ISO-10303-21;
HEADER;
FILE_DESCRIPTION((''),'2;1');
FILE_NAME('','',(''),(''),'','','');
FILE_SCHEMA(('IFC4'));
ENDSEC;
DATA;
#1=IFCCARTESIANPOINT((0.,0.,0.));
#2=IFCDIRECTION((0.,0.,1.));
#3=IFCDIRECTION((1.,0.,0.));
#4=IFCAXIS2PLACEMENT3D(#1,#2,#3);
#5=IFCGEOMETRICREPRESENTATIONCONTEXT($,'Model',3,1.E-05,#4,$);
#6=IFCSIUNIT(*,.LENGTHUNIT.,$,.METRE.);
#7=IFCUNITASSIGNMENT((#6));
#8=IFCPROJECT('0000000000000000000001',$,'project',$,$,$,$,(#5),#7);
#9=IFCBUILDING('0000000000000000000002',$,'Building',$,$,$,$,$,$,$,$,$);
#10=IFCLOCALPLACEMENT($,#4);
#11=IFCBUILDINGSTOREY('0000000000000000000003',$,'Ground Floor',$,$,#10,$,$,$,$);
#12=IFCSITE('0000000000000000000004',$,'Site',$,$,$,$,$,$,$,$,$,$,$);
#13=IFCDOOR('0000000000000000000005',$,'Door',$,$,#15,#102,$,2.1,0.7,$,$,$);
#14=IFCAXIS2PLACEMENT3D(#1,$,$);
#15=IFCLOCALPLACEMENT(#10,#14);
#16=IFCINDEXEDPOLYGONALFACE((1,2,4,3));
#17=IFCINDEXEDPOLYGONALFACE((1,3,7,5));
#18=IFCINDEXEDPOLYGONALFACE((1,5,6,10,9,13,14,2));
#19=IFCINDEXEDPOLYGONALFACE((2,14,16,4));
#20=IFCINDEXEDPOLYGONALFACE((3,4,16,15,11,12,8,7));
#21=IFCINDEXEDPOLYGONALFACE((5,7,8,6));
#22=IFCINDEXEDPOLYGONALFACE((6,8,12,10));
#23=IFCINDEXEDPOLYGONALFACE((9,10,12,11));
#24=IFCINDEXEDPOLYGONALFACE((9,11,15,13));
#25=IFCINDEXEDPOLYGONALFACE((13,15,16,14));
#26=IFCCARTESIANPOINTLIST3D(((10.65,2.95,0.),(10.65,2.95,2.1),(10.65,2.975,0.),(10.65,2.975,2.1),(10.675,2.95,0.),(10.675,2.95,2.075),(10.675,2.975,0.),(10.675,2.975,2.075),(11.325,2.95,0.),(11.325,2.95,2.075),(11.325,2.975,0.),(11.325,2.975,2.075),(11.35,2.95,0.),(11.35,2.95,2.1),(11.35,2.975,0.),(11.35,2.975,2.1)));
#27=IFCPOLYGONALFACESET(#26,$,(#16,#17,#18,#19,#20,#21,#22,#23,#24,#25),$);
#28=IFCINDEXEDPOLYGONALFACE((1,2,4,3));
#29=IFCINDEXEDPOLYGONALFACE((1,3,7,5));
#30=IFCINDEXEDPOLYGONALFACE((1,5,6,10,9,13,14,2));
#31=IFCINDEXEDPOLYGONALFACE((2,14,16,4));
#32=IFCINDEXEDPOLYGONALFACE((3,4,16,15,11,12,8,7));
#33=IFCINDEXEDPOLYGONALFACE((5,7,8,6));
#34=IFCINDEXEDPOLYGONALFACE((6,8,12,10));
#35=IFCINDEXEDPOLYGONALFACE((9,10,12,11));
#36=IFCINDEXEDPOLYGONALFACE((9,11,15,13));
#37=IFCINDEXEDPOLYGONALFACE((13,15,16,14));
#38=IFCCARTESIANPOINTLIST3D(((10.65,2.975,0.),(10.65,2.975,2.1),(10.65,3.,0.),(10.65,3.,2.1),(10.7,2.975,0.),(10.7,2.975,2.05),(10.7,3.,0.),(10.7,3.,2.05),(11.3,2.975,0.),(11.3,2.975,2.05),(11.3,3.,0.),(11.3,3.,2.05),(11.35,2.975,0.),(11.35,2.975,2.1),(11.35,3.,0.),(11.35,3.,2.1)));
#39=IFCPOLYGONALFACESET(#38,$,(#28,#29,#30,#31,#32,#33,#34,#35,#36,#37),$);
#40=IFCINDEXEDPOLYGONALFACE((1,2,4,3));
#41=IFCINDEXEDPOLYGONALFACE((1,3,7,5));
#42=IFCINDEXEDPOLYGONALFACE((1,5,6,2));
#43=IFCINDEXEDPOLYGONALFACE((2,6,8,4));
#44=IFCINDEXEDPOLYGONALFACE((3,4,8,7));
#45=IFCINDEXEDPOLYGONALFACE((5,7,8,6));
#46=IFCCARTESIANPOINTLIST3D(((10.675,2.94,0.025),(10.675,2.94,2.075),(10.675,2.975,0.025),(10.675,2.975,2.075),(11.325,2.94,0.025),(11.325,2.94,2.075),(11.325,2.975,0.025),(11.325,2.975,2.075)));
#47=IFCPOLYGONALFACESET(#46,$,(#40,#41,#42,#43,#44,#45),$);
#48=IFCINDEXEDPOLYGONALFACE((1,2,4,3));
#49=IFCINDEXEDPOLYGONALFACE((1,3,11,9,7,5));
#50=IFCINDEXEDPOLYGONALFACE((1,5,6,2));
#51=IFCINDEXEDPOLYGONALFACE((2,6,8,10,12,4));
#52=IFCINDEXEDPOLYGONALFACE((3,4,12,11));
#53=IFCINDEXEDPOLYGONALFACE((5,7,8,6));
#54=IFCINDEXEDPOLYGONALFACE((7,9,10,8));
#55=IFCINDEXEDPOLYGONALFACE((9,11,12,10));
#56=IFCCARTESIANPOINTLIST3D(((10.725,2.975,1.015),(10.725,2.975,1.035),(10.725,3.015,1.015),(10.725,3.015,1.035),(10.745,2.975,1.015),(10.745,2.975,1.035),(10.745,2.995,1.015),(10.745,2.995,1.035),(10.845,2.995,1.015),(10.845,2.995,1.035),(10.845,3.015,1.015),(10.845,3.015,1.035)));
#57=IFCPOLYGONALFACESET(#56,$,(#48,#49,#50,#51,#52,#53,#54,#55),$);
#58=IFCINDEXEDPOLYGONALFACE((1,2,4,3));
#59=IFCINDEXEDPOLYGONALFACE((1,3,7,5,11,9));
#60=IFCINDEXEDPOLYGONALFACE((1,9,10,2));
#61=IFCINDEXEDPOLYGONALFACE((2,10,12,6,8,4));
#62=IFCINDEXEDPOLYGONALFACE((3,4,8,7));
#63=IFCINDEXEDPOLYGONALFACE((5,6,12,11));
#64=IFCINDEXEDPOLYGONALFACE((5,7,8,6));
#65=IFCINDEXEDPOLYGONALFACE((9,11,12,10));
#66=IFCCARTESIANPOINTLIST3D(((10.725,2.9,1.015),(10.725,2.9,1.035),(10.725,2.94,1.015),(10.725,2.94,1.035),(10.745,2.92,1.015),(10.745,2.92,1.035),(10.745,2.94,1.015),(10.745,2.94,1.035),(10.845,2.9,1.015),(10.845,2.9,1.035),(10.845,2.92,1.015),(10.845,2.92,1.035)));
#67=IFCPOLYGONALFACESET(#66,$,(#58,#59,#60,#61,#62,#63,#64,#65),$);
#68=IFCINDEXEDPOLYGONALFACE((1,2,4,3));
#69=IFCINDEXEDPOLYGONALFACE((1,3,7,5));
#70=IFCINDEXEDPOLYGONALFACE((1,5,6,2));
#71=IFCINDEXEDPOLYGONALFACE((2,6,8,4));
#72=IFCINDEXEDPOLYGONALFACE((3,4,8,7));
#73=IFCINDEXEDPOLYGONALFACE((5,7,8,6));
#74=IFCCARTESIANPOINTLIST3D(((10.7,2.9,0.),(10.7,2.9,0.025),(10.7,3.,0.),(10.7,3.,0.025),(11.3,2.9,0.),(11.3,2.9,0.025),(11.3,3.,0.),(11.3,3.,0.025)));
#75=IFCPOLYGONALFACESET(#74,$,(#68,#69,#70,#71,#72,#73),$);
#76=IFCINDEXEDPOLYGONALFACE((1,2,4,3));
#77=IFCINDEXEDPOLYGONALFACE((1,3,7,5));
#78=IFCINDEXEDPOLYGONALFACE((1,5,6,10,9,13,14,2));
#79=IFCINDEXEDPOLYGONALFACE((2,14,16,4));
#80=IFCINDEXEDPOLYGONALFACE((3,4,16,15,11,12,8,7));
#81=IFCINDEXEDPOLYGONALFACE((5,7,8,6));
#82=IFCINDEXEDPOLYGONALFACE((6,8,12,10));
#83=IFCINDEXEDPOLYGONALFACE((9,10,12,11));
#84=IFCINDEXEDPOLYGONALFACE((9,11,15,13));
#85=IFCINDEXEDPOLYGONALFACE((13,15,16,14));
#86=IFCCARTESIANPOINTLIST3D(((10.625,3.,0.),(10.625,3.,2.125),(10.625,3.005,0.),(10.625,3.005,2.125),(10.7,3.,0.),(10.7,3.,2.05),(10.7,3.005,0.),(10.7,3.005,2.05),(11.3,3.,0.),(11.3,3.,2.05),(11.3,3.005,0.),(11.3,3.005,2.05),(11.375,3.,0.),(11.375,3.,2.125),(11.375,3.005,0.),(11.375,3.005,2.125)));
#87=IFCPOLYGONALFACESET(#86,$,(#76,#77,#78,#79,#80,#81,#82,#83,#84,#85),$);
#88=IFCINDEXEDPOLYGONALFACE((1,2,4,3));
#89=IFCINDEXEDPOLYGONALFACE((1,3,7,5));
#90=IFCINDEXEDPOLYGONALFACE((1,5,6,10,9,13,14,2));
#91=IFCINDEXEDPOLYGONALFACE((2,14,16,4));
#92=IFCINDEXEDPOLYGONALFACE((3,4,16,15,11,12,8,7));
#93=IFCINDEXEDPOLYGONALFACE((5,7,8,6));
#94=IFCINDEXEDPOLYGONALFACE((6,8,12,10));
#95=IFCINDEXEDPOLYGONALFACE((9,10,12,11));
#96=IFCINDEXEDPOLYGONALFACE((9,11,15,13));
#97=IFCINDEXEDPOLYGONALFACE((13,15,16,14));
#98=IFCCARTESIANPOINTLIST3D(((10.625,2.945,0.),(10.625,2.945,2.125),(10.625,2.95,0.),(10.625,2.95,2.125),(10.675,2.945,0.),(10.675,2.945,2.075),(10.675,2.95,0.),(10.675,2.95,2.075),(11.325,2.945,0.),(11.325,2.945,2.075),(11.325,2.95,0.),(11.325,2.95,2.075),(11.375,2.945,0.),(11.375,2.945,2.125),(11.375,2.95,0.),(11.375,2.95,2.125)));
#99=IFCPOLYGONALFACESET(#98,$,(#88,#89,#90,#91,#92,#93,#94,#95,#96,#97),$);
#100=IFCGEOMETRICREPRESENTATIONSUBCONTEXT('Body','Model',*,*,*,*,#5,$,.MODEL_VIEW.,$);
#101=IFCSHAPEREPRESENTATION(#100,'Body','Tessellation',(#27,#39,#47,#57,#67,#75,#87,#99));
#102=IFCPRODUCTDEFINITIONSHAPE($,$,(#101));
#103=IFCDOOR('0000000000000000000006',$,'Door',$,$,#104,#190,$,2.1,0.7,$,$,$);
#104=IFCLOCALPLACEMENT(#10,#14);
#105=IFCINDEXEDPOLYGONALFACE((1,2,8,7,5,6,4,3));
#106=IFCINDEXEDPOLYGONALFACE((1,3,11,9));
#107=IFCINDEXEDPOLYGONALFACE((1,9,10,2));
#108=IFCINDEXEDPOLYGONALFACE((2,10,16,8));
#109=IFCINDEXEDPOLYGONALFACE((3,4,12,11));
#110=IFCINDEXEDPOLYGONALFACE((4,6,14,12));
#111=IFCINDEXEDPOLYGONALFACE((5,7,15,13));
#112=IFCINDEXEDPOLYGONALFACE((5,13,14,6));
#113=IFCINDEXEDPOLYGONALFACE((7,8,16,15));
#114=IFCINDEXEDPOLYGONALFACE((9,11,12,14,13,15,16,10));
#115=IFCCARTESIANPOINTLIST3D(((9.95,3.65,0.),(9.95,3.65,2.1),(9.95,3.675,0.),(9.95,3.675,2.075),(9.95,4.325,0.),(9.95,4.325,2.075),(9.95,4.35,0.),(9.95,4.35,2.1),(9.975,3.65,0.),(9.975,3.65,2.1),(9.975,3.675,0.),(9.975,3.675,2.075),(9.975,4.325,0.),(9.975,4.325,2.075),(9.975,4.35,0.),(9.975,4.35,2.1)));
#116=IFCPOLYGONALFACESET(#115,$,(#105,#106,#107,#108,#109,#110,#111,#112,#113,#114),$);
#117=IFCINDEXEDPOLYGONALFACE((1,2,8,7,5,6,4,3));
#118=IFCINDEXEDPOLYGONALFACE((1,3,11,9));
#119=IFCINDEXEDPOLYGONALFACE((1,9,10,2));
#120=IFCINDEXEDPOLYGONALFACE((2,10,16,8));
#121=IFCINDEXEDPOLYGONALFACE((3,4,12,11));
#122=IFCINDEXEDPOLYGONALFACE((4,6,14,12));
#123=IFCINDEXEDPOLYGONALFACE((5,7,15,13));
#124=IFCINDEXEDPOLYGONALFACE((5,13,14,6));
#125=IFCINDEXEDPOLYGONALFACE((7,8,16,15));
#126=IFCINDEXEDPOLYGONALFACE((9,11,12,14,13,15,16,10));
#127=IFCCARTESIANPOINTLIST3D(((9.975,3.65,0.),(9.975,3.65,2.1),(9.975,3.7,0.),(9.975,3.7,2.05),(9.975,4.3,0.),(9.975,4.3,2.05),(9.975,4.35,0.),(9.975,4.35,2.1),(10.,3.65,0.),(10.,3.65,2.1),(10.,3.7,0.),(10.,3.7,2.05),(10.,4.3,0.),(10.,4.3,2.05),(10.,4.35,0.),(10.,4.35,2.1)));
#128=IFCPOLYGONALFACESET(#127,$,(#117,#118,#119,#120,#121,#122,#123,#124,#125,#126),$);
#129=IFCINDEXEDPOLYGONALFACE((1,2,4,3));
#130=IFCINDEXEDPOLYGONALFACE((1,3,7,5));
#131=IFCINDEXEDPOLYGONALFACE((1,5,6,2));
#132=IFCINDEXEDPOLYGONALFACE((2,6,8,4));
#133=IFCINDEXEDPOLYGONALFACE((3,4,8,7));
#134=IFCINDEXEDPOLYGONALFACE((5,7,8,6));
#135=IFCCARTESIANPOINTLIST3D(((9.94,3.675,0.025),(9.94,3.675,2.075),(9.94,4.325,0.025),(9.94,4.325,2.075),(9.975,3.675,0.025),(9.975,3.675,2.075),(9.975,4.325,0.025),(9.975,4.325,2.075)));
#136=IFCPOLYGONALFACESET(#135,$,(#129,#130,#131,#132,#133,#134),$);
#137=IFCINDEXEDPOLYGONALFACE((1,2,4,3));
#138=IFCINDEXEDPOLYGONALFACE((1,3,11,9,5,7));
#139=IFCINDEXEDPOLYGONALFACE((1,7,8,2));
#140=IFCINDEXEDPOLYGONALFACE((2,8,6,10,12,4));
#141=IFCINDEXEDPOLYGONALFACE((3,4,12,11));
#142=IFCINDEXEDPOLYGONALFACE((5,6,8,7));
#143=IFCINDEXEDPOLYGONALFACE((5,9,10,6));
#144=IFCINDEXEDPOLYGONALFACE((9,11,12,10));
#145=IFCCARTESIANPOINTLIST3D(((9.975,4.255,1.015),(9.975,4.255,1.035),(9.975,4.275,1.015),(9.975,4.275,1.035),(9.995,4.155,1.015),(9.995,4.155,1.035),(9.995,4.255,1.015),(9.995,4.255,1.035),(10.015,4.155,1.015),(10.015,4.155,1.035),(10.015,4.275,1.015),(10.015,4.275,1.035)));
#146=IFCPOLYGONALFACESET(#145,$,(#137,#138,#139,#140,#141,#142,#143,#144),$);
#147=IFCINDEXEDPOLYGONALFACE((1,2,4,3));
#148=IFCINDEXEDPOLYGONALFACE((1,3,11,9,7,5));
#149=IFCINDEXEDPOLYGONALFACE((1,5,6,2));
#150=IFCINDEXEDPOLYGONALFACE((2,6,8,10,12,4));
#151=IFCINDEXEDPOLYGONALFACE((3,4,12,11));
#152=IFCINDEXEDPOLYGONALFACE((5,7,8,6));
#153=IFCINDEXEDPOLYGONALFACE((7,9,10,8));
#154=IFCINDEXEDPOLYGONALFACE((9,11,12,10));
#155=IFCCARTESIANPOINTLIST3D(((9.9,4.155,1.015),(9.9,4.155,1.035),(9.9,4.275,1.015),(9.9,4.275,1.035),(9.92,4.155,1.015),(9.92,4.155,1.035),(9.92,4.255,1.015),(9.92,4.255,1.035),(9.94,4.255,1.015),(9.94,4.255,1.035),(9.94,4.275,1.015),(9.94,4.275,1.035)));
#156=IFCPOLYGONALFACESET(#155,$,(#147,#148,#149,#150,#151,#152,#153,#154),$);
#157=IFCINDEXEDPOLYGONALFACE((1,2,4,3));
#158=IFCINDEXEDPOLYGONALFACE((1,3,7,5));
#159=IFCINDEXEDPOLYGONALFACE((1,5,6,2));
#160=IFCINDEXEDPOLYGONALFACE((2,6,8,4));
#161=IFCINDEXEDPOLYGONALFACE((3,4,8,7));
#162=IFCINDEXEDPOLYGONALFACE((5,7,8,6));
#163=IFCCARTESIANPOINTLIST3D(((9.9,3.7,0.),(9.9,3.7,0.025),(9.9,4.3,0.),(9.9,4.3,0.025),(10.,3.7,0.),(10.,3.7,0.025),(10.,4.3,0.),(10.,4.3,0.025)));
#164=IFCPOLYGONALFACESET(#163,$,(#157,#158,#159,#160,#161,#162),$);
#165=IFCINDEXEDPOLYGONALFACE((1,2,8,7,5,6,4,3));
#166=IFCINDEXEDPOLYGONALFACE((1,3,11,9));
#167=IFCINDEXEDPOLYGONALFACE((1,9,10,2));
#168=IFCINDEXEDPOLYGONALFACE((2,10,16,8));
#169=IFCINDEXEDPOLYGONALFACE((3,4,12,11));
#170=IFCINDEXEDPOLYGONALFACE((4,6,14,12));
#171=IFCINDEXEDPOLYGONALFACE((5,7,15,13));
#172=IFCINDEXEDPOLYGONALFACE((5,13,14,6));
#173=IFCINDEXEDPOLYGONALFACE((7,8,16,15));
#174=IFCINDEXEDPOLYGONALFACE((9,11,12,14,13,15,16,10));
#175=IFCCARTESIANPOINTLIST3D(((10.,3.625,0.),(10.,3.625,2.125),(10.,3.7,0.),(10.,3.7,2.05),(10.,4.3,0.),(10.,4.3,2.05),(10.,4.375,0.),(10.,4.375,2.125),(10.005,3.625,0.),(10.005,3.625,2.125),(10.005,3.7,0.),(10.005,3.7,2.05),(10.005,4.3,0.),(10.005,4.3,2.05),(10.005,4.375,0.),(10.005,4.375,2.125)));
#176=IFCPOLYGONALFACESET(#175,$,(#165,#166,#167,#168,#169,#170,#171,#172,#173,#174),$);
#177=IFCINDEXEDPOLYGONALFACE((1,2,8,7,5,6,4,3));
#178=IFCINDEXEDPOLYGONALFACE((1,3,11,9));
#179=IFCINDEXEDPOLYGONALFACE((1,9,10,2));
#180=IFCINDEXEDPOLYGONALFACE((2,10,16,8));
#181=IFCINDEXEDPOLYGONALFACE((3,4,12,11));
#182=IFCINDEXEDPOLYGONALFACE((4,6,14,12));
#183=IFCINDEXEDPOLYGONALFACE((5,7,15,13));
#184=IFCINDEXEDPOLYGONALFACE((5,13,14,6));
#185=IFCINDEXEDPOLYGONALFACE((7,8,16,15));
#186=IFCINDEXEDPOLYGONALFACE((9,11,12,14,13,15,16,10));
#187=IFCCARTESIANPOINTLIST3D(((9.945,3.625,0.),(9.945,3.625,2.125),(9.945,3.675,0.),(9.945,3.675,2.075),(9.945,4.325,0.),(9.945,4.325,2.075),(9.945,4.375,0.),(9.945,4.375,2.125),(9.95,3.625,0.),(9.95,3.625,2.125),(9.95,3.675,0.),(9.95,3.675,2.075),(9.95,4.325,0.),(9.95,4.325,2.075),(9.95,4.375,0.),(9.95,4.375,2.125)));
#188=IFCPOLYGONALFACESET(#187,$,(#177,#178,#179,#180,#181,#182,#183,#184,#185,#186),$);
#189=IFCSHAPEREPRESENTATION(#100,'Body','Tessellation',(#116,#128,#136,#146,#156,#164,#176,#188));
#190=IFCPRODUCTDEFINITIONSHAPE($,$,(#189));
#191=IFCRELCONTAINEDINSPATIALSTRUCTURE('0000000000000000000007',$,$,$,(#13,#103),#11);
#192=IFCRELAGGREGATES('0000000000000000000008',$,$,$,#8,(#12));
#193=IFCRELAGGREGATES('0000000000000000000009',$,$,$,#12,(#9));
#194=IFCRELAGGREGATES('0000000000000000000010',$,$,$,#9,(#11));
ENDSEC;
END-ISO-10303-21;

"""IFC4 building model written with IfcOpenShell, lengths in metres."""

from ifc_helpers import new_model, si_unit, frame, origin_with_axes, place, context, subcontext, project, spatial, line, indexed_curve, outline, extrude, element, save


model = new_model("IFC4")

# Units and contexts
model_context = context("Model", 3, precision=1e-05, world=origin_with_axes())
body_context = subcontext(model_context, "Body", "Model", "MODEL_VIEW")
ifc_project = project(units=[si_unit("LENGTHUNIT", "METRE")], contexts=[model_context])

# Site, building, storey
site = spatial("IfcSite", under=ifc_project, Name="Site")
building = spatial("IfcBuilding", under=site, Name="Building")
storey_placement = place(None, origin_with_axes())
storey = spatial("IfcBuildingStorey", under=building, at=storey_placement, Name="Ground Floor")

# Doors
door_1_placement = place(storey_placement, frame((11.35, 3.0, 0.0), z_axis=(0.0, 0.0, 1.0), x_axis=(-1.0, 0.0, 0.0)))
element("IfcDoor", 1, at=door_1_placement, inside=storey, Name="Door", OverallHeight=2.1, OverallWidth=0.7, context=body_context, shape_type="SweptSolid", body=[
    extrude(outline(indexed_curve([(0.0, 0.0), (0.0, 2.1), (0.7, 2.1), (0.7, 0.0), (0.675, 0.0), (0.675, 2.075), (0.025, 2.075), (0.025, 0.0)], segments=[line(1, 2, 3, 4, 5, 6, 7, 8, 1)])), frame((0.0, 0.025, 0.0), z_axis=(0.0, -1.0, 0.0), x_axis=(1.0, 0.0, 0.0)), (0.0, 0.0, -1.0), 0.025),
    extrude(outline(indexed_curve([(0.0, 0.0), (0.0, 2.1), (0.7, 2.1), (0.7, 0.0), (0.65, 0.0), (0.65, 2.05), (0.05, 2.05), (0.05, 0.0)], segments=[line(1, 2, 3, 4, 5, 6, 7, 8, 1)])), frame((0.0, 0.0, 0.0), z_axis=(0.0, -1.0, 0.0), x_axis=(1.0, 0.0, 0.0)), (0.0, 0.0, -1.0), 0.025),
    extrude(outline(indexed_curve([(0.0, 0.0), (0.65, 0.0), (0.65, 0.035), (0.0, 0.035)], segments=[line(1, 2, 3, 4, 1)])), frame((0.025, 0.025, 0.025), z_axis=(0.0, 0.0, 1.0), x_axis=(1.0, 0.0, 0.0)), (0.0, 0.0, 1.0), 2.05),
    extrude(outline(indexed_curve([(0.0, 0.0), (0.0, -0.04), (-0.12, -0.04), (-0.12, -0.02), (-0.02, -0.02), (-0.02, 0.0)], segments=[line(1, 2, 3, 4, 5, 6, 1)])), frame((0.625, 0.025, 1.015), z_axis=(0.0, 0.0, 1.0), x_axis=(1.0, 0.0, 0.0)), (0.0, 0.0, 1.0), 0.02),
    extrude(outline(indexed_curve([(0.0, 0.0), (0.0, 0.04), (-0.12, 0.04), (-0.12, 0.02), (-0.02, 0.02), (-0.02, 0.0)], segments=[line(1, 2, 3, 4, 5, 6, 1)])), frame((0.625, 0.06, 1.015), z_axis=(0.0, 0.0, 1.0), x_axis=(1.0, 0.0, 0.0)), (0.0, 0.0, 1.0), 0.02),
    extrude(outline(indexed_curve([(0.0, 0.0), (0.6, 0.0), (0.6, 0.1), (0.0, 0.1)], segments=[line(1, 2, 3, 4, 1)])), frame((0.05, 0.0, 0.0), z_axis=(0.0, 0.0, 1.0), x_axis=(1.0, 0.0, 0.0)), (0.0, 0.0, 1.0), 0.025),
    extrude(outline(indexed_curve([(0.0, 0.0), (0.0, 2.125), (0.75, 2.125), (0.75, 0.0), (0.675, 0.0), (0.675, 2.05), (0.075, 2.05), (0.075, 0.0)], segments=[line(1, 2, 3, 4, 5, 6, 7, 8, 1)])), frame((-0.025, -0.005, 0.0), z_axis=(0.0, -1.0, 0.0), x_axis=(1.0, 0.0, 0.0)), (0.0, 0.0, -1.0), 0.005),
    extrude(outline(indexed_curve([(0.0, 0.0), (0.0, 2.125), (0.75, 2.125), (0.75, 0.0), (0.7, 0.0), (0.7, 2.075), (0.05, 2.075), (0.05, 0.0)], segments=[line(1, 2, 3, 4, 5, 6, 7, 8, 1)])), frame((-0.025, 0.05, 0.0), z_axis=(0.0, -1.0, 0.0), x_axis=(1.0, 0.0, 0.0)), (0.0, 0.0, -1.0), 0.005),
])
door_2_placement = place(storey_placement, frame((10.0, 3.65, 0.0), z_axis=(0.0, 0.0, 1.0), x_axis=(0.0, 1.0, 0.0)))
element("IfcDoor", 2, at=door_2_placement, inside=storey, Name="Door", OverallHeight=2.1, OverallWidth=0.7, context=body_context, shape_type="SweptSolid", body=[
    extrude(outline(indexed_curve([(0.0, 0.0), (0.0, 2.1), (0.7, 2.1), (0.7, 0.0), (0.675, 0.0), (0.675, 2.075), (0.025, 2.075), (0.025, 0.0)], segments=[line(1, 2, 3, 4, 5, 6, 7, 8, 1)])), frame((0.0, 0.025, 0.0), z_axis=(0.0, -1.0, 0.0), x_axis=(1.0, 0.0, 0.0)), (0.0, 0.0, -1.0), 0.025),
    extrude(outline(indexed_curve([(0.0, 0.0), (0.0, 2.1), (0.7, 2.1), (0.7, 0.0), (0.65, 0.0), (0.65, 2.05), (0.05, 2.05), (0.05, 0.0)], segments=[line(1, 2, 3, 4, 5, 6, 7, 8, 1)])), frame((0.0, 0.0, 0.0), z_axis=(0.0, -1.0, 0.0), x_axis=(1.0, 0.0, 0.0)), (0.0, 0.0, -1.0), 0.025),
    extrude(outline(indexed_curve([(0.0, 0.0), (0.65, 0.0), (0.65, 0.035), (0.0, 0.035)], segments=[line(1, 2, 3, 4, 1)])), frame((0.025, 0.025, 0.025), z_axis=(0.0, 0.0, 1.0), x_axis=(1.0, 0.0, 0.0)), (0.0, 0.0, 1.0), 2.05),
    extrude(outline(indexed_curve([(0.0, 0.0), (0.0, -0.04), (-0.12, -0.04), (-0.12, -0.02), (-0.02, -0.02), (-0.02, 0.0)], segments=[line(1, 2, 3, 4, 5, 6, 1)])), frame((0.625, 0.025, 1.015), z_axis=(0.0, 0.0, 1.0), x_axis=(1.0, 0.0, 0.0)), (0.0, 0.0, 1.0), 0.02),
    extrude(outline(indexed_curve([(0.0, 0.0), (0.0, 0.04), (-0.12, 0.04), (-0.12, 0.02), (-0.02, 0.02), (-0.02, 0.0)], segments=[line(1, 2, 3, 4, 5, 6, 1)])), frame((0.625, 0.06, 1.015), z_axis=(0.0, 0.0, 1.0), x_axis=(1.0, 0.0, 0.0)), (0.0, 0.0, 1.0), 0.02),
    extrude(outline(indexed_curve([(0.0, 0.0), (0.6, 0.0), (0.6, 0.1), (0.0, 0.1)], segments=[line(1, 2, 3, 4, 1)])), frame((0.05, 0.0, 0.0), z_axis=(0.0, 0.0, 1.0), x_axis=(1.0, 0.0, 0.0)), (0.0, 0.0, 1.0), 0.025),
    extrude(outline(indexed_curve([(0.0, 0.0), (0.0, 2.125), (0.75, 2.125), (0.75, 0.0), (0.675, 0.0), (0.675, 2.05), (0.075, 2.05), (0.075, 0.0)], segments=[line(1, 2, 3, 4, 5, 6, 7, 8, 1)])), frame((-0.025, -0.005, 0.0), z_axis=(0.0, -1.0, 0.0), x_axis=(1.0, 0.0, 0.0)), (0.0, 0.0, -1.0), 0.005),
    extrude(outline(indexed_curve([(0.0, 0.0), (0.0, 2.125), (0.75, 2.125), (0.75, 0.0), (0.7, 0.0), (0.7, 2.075), (0.05, 2.075), (0.05, 0.0)], segments=[line(1, 2, 3, 4, 5, 6, 7, 8, 1)])), frame((-0.025, 0.05, 0.0), z_axis=(0.0, -1.0, 0.0), x_axis=(1.0, 0.0, 0.0)), (0.0, 0.0, -1.0), 0.005),
])

save(model, "model.ifc")
